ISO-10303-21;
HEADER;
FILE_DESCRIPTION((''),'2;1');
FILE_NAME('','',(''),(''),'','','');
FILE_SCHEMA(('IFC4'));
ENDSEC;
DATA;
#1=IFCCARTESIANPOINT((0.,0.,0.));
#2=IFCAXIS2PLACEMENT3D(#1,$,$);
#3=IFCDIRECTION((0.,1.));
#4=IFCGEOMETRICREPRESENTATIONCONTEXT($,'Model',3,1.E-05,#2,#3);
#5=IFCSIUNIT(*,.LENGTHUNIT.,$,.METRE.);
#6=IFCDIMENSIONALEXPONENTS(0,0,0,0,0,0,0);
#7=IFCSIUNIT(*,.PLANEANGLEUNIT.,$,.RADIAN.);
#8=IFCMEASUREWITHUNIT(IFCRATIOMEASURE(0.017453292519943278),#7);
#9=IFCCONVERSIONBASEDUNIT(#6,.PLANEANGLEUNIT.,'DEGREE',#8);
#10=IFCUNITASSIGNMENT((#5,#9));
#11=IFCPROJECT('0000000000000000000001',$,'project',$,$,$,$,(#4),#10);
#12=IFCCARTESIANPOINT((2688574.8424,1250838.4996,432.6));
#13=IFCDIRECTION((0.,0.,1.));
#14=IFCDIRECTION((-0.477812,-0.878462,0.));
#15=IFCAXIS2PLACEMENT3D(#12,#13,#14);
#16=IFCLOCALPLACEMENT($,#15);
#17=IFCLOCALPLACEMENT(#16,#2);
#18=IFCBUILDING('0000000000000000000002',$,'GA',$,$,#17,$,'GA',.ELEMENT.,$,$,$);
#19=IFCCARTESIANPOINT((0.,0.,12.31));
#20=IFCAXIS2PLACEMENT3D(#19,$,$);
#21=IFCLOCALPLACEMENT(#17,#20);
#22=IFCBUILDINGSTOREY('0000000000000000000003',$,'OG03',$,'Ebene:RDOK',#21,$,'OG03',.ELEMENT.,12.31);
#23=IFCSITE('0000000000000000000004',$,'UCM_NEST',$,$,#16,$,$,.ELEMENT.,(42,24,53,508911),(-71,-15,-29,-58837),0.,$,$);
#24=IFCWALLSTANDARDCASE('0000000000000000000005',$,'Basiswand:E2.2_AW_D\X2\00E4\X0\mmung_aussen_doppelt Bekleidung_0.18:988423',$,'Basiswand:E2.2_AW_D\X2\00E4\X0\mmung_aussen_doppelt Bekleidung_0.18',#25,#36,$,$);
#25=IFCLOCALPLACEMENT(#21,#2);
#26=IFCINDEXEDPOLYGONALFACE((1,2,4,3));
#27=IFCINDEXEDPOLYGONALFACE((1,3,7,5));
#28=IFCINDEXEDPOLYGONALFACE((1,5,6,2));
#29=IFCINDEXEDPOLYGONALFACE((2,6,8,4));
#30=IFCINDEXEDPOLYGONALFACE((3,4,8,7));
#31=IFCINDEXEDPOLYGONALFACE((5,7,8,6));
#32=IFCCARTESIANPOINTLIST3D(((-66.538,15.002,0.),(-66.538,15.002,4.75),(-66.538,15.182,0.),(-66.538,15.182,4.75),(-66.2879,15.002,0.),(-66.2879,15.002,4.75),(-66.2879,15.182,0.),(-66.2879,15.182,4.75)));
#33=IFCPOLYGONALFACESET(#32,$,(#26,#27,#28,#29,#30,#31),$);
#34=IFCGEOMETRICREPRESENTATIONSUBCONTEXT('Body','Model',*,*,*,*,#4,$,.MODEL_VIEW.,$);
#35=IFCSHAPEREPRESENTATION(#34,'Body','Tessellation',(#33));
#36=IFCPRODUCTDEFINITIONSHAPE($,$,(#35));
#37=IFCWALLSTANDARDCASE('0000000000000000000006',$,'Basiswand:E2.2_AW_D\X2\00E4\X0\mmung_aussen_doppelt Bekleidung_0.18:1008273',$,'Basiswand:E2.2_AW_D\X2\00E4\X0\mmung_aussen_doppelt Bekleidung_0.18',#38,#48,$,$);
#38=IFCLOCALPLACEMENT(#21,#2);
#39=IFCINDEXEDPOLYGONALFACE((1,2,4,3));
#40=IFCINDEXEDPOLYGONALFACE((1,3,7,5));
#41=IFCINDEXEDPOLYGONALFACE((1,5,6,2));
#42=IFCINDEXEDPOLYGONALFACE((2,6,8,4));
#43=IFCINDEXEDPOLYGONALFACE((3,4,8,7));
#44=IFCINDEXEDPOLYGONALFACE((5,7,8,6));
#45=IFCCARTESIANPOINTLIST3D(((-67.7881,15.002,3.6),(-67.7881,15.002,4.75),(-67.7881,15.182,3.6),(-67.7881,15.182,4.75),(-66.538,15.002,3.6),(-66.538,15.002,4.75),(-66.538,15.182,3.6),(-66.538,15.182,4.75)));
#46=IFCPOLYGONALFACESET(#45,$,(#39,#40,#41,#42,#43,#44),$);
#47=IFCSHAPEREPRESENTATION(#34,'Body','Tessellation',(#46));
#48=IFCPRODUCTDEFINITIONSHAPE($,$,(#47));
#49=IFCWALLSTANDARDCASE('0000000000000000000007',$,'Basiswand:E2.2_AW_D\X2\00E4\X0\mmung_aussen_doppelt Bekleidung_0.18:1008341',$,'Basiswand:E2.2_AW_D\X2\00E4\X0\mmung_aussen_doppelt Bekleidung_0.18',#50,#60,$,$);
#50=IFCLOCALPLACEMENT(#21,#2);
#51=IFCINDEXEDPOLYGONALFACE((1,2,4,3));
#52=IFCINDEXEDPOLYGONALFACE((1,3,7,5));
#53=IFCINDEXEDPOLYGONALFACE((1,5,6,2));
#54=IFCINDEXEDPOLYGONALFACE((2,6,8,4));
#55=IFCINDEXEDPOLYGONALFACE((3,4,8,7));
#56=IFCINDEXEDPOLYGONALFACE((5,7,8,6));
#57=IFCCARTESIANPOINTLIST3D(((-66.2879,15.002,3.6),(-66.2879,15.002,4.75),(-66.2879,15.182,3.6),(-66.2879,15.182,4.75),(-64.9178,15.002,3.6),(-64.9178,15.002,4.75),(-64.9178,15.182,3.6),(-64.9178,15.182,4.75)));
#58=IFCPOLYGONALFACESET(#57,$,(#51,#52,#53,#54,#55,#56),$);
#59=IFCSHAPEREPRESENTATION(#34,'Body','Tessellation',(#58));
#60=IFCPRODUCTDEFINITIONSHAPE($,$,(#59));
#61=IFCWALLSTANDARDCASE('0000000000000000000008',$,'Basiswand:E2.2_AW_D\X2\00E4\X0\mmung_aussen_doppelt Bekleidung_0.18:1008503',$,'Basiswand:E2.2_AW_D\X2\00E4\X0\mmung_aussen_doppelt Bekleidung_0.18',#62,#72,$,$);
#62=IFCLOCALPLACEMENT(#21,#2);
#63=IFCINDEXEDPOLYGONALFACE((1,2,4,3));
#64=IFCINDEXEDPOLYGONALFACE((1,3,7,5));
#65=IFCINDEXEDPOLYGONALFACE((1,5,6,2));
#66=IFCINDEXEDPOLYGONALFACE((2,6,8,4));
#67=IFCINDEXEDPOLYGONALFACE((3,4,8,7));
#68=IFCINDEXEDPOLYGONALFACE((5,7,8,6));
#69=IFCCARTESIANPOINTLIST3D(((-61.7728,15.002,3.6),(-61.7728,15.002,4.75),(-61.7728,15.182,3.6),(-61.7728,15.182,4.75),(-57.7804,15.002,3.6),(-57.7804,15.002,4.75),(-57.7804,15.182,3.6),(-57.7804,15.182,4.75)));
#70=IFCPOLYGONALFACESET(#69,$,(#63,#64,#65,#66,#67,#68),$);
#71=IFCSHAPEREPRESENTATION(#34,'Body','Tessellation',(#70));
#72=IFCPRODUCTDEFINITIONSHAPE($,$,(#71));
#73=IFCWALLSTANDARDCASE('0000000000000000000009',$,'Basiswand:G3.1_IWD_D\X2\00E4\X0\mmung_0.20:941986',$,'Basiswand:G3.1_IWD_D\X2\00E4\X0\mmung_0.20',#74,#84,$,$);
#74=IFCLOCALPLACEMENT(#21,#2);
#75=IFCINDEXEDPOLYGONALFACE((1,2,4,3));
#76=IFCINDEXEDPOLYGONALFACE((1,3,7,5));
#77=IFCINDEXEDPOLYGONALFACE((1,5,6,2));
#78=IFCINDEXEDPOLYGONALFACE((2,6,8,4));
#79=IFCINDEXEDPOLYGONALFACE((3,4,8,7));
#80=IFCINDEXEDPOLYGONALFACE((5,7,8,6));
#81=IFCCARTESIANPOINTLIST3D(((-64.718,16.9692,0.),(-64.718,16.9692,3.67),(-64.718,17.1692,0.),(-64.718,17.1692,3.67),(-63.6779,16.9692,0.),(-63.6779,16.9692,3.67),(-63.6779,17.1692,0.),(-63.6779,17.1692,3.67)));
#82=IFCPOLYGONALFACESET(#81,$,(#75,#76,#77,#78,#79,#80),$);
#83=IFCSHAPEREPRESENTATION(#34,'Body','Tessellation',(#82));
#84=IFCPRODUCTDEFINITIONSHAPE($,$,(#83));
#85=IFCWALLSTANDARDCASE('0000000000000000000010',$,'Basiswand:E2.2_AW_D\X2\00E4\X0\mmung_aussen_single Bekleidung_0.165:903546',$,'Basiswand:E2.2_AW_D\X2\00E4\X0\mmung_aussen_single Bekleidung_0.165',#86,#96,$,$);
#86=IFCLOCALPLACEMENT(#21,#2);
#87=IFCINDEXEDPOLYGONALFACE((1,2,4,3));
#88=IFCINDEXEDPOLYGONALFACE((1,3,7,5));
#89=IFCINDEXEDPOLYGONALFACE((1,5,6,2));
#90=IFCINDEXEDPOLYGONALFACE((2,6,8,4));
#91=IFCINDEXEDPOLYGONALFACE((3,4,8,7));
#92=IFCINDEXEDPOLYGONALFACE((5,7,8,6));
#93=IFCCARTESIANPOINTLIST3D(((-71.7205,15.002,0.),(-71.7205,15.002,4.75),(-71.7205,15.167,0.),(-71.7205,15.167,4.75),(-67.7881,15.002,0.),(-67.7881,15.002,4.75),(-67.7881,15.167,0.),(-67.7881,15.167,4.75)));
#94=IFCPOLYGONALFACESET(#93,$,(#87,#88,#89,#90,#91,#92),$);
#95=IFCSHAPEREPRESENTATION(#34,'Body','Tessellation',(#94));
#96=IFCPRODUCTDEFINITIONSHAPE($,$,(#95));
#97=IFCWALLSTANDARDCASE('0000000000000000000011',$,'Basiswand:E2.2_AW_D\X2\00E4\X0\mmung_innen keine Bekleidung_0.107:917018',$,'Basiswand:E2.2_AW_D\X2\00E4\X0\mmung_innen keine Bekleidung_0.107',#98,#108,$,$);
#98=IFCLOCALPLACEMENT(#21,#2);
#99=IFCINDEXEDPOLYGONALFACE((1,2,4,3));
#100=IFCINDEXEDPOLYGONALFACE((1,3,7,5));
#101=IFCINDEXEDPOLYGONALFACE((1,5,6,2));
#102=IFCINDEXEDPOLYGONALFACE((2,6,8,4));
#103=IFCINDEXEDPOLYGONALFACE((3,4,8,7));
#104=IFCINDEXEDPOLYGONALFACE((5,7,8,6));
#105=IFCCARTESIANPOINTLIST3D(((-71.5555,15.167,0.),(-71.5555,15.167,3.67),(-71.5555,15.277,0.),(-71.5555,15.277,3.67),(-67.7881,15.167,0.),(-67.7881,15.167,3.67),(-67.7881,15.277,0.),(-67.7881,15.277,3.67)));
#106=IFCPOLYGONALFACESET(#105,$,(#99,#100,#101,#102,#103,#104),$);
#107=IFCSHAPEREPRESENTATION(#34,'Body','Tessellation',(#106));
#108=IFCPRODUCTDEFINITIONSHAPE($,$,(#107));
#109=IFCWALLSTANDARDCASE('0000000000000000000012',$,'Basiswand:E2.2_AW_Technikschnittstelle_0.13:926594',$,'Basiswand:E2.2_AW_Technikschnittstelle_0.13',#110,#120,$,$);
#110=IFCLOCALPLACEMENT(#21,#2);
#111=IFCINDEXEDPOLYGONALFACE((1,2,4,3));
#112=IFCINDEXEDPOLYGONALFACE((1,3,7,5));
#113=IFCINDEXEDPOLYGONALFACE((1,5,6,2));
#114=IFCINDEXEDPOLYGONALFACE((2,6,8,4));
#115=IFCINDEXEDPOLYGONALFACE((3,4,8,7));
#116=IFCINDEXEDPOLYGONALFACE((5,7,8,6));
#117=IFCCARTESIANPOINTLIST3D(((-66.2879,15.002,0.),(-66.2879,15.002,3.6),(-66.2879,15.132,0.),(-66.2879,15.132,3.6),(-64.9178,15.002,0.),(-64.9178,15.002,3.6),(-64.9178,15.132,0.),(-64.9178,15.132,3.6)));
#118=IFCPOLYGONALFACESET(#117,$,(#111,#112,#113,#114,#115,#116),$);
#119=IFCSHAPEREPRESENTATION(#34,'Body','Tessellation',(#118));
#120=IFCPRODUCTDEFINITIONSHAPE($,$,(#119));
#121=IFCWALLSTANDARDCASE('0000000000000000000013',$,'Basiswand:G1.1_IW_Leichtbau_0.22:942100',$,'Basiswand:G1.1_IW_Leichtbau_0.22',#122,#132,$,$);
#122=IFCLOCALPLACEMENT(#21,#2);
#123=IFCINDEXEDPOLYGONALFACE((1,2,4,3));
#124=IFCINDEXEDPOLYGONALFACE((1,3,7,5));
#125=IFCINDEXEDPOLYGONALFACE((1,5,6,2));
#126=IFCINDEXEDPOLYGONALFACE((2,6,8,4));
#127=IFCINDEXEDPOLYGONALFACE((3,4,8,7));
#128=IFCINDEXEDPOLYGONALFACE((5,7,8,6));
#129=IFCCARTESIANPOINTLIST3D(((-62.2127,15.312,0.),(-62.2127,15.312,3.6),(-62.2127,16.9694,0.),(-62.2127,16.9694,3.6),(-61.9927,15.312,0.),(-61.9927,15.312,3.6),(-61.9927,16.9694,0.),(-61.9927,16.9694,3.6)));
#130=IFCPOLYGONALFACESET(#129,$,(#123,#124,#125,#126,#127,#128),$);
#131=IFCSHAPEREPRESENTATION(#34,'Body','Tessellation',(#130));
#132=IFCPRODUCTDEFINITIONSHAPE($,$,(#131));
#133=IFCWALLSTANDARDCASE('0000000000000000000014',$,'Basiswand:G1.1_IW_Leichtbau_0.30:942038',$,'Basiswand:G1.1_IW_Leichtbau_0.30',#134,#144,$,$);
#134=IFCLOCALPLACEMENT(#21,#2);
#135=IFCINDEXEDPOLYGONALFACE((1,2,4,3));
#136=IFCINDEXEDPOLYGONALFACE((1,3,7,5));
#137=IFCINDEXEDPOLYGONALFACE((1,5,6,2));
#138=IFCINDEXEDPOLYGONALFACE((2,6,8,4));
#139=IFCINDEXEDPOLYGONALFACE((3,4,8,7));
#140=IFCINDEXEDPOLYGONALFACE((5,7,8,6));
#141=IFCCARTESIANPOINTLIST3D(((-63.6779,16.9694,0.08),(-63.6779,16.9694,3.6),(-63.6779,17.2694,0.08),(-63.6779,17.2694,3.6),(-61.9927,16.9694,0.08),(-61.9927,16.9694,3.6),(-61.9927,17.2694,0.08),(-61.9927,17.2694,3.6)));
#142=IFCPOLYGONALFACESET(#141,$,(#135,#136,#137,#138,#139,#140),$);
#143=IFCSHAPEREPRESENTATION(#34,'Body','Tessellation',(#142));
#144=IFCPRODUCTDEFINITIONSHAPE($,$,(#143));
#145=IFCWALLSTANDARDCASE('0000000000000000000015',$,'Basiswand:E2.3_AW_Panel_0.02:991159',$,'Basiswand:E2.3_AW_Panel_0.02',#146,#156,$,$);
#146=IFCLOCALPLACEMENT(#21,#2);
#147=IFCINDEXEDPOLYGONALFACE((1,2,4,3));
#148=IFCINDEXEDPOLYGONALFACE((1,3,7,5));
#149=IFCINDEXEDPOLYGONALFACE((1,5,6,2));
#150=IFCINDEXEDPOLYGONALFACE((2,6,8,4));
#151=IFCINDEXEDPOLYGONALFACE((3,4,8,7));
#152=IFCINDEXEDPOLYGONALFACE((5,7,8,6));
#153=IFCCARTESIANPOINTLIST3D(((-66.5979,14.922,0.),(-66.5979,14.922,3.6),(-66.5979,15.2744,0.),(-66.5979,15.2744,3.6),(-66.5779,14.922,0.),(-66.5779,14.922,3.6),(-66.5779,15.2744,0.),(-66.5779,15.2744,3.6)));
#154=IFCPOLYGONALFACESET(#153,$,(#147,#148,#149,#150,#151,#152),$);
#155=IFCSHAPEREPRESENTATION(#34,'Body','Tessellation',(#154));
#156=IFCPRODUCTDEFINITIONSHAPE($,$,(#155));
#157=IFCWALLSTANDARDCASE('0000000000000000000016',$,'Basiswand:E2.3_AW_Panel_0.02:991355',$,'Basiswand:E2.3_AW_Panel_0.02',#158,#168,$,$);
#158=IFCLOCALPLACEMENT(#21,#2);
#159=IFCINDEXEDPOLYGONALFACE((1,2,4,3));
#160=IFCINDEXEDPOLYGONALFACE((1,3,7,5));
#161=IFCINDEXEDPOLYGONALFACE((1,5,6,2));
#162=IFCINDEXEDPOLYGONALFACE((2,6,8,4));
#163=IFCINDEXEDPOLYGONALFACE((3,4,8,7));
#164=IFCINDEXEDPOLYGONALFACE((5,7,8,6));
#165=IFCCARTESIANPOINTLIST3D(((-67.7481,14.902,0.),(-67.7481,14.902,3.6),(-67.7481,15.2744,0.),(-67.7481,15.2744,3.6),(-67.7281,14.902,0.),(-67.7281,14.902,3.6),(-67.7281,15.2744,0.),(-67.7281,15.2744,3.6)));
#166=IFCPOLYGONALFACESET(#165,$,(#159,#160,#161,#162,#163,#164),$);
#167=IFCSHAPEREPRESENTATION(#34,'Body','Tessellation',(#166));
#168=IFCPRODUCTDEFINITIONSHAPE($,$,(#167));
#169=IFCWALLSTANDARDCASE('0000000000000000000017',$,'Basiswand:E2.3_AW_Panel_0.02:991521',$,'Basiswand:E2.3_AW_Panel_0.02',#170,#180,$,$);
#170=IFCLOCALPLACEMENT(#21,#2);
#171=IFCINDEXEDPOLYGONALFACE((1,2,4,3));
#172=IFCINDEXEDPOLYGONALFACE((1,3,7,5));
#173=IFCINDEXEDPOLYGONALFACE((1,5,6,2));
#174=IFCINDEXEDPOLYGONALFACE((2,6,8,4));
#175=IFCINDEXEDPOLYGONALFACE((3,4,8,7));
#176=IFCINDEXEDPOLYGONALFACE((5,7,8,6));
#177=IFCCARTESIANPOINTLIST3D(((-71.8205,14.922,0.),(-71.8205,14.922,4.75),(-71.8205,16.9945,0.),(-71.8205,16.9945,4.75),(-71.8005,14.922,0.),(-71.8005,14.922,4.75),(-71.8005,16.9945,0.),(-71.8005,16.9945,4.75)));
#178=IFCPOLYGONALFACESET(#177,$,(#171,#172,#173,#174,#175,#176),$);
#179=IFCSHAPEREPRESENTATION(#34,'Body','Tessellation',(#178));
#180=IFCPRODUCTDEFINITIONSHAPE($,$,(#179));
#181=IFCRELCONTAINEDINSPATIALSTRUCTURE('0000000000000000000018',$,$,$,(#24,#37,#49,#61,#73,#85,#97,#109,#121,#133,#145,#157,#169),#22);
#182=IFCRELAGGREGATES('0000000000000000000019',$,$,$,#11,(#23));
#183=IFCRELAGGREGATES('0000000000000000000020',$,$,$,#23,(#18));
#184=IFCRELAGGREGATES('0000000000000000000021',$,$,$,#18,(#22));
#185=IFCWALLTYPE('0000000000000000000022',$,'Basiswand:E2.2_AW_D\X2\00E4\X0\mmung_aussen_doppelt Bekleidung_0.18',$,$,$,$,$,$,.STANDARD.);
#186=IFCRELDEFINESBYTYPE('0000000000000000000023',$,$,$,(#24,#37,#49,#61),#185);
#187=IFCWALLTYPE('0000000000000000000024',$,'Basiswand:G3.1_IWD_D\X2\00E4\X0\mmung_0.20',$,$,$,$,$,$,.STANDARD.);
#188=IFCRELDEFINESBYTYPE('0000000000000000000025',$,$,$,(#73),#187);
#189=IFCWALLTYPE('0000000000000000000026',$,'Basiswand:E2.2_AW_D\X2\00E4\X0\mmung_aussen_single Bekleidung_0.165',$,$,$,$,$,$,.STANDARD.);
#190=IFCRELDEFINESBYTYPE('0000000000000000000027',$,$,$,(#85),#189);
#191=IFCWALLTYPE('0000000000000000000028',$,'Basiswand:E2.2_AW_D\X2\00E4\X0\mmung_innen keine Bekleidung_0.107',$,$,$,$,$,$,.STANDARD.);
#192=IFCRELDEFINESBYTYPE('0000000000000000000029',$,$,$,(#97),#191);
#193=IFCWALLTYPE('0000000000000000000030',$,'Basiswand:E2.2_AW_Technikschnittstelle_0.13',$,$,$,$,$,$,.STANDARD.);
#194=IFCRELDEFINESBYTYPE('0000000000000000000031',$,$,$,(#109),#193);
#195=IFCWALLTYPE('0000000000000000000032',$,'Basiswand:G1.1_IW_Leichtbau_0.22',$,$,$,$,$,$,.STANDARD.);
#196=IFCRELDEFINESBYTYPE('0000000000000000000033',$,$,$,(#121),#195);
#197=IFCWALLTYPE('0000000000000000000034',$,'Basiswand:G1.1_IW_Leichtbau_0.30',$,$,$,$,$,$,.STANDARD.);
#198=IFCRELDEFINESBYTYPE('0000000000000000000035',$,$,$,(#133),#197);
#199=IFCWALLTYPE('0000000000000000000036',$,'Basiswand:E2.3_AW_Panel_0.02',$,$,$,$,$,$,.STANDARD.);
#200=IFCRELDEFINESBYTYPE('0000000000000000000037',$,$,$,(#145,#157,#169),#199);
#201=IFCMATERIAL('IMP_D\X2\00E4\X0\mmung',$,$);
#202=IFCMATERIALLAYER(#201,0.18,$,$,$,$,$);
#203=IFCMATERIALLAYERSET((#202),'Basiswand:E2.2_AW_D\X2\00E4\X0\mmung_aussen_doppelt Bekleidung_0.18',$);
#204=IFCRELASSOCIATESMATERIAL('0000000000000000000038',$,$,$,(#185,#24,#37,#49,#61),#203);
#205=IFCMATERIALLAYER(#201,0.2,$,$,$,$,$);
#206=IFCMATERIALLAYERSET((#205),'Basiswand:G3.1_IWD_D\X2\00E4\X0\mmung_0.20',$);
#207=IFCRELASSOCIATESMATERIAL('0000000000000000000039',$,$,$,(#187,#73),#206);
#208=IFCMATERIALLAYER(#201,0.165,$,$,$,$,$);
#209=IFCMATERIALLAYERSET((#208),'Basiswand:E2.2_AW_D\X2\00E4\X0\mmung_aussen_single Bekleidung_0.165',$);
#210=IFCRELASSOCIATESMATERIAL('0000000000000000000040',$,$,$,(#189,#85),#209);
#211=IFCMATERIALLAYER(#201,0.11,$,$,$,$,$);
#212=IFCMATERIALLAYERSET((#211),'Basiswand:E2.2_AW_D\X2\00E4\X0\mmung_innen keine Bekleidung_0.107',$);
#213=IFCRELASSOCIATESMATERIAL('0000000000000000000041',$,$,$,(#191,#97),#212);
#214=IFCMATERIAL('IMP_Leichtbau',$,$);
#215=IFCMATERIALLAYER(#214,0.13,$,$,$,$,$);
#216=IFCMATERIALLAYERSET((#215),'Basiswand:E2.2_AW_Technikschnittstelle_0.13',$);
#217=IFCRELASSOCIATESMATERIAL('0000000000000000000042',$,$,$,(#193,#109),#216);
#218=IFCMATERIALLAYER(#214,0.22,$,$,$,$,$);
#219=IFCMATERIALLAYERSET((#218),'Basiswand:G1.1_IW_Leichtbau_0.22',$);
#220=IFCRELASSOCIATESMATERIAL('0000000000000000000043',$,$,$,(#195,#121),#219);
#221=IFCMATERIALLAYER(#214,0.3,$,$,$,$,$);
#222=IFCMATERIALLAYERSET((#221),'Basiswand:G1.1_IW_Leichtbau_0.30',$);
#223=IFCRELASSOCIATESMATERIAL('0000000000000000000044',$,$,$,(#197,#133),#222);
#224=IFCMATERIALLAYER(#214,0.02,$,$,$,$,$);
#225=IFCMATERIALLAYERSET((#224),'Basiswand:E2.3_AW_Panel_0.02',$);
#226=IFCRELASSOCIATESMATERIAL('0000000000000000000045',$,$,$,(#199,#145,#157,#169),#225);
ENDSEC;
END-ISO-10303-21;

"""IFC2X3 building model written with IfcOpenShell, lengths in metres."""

from ifc_helpers import new_model, entity, si_unit, converted_unit, direction, frame, frame_2d, origin, place, context, subcontext, project, spatial, polyline, rectangle, extrude, clip, bounded_halfspace, material, layer, layer_set, layer_usage, type_object, element, save


model = new_model("IFC2X3")

# Units and contexts
model_context = context("Model", 3, precision=1e-05, world=origin(), true_north=direction((0.0, 1.0)))
body_context = subcontext(model_context, "Body", "Model", "MODEL_VIEW")
ifc_project = project(units=[si_unit("LENGTHUNIT", "METRE"), converted_unit("PLANEANGLEUNIT", "DEGREE", entity("IfcRatioMeasure", 0.017453292519943278), si_unit("PLANEANGLEUNIT", "RADIAN"), dimensions=[0, 0, 0, 0, 0, 0, 0])], contexts=[model_context])

# Site, building, storey
site_placement = place(None, frame((2688574.8424, 1250838.4996, 432.6), z_axis=(0.0, 0.0, 1.0), x_axis=(-0.477812, -0.878462, 0.0)))
site = spatial("IfcSite", under=ifc_project, at=site_placement, Name="UCM_NEST", CompositionType="ELEMENT", RefLatitude=(42, 24, 53, 508911), RefLongitude=(-71, -15, -29, -58837), RefElevation=0.0)
building_placement = place(site_placement, origin())
building = spatial("IfcBuilding", under=site, at=building_placement, Name="GA", LongName="GA", CompositionType="ELEMENT")
storey_placement = place(building_placement, frame((0.0, 0.0, 12.31)))
storey = spatial("IfcBuildingStorey", under=building, at=storey_placement, Name="OG03", ObjectType="Ebene:RDOK", LongName="OG03", CompositionType="ELEMENT", Elevation=12.31)

# Walls
ifc_material_1 = material(Name="IMP_Dämmung")
ifc_layer_1 = layer(ifc_material_1, 0.18)
ifc_layer_set_1 = layer_set([ifc_layer_1], Name="Basiswand:E2.2_AW_Dämmung_aussen_doppelt Bekleidung_0.18")
ifc_layer_usage_1 = layer_usage(ifc_layer_set_1, "AXIS2", "NEGATIVE", 0.09)
wall_type_1 = type_object("IfcWallType", Name="Basiswand:E2.2_AW_Dämmung_aussen_doppelt Bekleidung_0.18", PredefinedType="STANDARD", material=ifc_layer_set_1)
wall_1_placement = place(storey_placement, frame((-66.2879, 15.092, 0.0), z_axis=(0.0, 0.0, 1.0), x_axis=(-1.0, 0.0, 0.0)))
element("IfcWallStandardCase", 1, at=wall_1_placement, inside=storey, type_object=wall_type_1, material=ifc_layer_usage_1, Name="Basiswand:E2.2_AW_Dämmung_aussen_doppelt Bekleidung_0.18:988423", ObjectType="Basiswand:E2.2_AW_Dämmung_aussen_doppelt Bekleidung_0.18", context=body_context, shape_type="SweptSolid", body=[
    extrude(rectangle(XDim=0.2502, YDim=0.18, at=frame_2d((0.1251, 0.0), x_axis=(-1.0, 0.0))), origin(), (0.0, 0.0, 1.0), 4.75),
])
wall_2_placement = place(storey_placement, frame((-67.7881, 15.092, 3.6)))
element("IfcWallStandardCase", 2, at=wall_2_placement, inside=storey, type_object=wall_type_1, material=ifc_layer_usage_1, Name="Basiswand:E2.2_AW_Dämmung_aussen_doppelt Bekleidung_0.18:1008273", ObjectType="Basiswand:E2.2_AW_Dämmung_aussen_doppelt Bekleidung_0.18", context=body_context, shape_type="SweptSolid", body=[
    extrude(rectangle(XDim=1.2501, YDim=0.18, at=frame_2d((0.625, 0.0), x_axis=(-1.0, 0.0))), origin(), (0.0, 0.0, 1.0), 1.15),
])
wall_3_placement = place(storey_placement, frame((-66.2879, 15.092, 3.6)))
element("IfcWallStandardCase", 3, at=wall_3_placement, inside=storey, type_object=wall_type_1, material=ifc_layer_usage_1, Name="Basiswand:E2.2_AW_Dämmung_aussen_doppelt Bekleidung_0.18:1008341", ObjectType="Basiswand:E2.2_AW_Dämmung_aussen_doppelt Bekleidung_0.18", context=body_context, shape_type="SweptSolid", body=[
    extrude(rectangle(XDim=1.3701, YDim=0.18, at=frame_2d((0.685, 0.0), x_axis=(-1.0, 0.0))), origin(), (0.0, 0.0, 1.0), 1.15),
])
wall_4_placement = place(storey_placement, frame((-61.7728, 15.092, 3.6)))
element("IfcWallStandardCase", 4, at=wall_4_placement, inside=storey, type_object=wall_type_1, material=ifc_layer_usage_1, Name="Basiswand:E2.2_AW_Dämmung_aussen_doppelt Bekleidung_0.18:1008503", ObjectType="Basiswand:E2.2_AW_Dämmung_aussen_doppelt Bekleidung_0.18", context=body_context, shape_type="SweptSolid", body=[
    extrude(rectangle(XDim=3.9923, YDim=0.18, at=frame_2d((1.9962, 0.0), x_axis=(-1.0, 0.0))), origin(), (0.0, 0.0, 1.0), 1.15),
])
ifc_layer_2 = layer(ifc_material_1, 0.2)
ifc_layer_set_2 = layer_set([ifc_layer_2], Name="Basiswand:G3.1_IWD_Dämmung_0.20")
ifc_layer_usage_2 = layer_usage(ifc_layer_set_2, "AXIS2", "NEGATIVE", 0.1)
wall_type_2 = type_object("IfcWallType", Name="Basiswand:G3.1_IWD_Dämmung_0.20", PredefinedType="STANDARD", material=ifc_layer_set_2)
wall_5_placement = place(storey_placement, frame((-64.718, 17.0692, 0.0)))
element("IfcWallStandardCase", 5, at=wall_5_placement, inside=storey, type_object=wall_type_2, material=ifc_layer_usage_2, Name="Basiswand:G3.1_IWD_Dämmung_0.20:941986", ObjectType="Basiswand:G3.1_IWD_Dämmung_0.20", context=body_context, shape_type="SweptSolid", body=[
    extrude(rectangle(XDim=1.0401, YDim=0.2, at=frame_2d((0.52, 0.0), x_axis=(-1.0, 0.0))), origin(), (0.0, 0.0, 1.0), 3.67),
])
ifc_layer_3 = layer(ifc_material_1, 0.165)
ifc_layer_set_3 = layer_set([ifc_layer_3], Name="Basiswand:E2.2_AW_Dämmung_aussen_single Bekleidung_0.165")
ifc_layer_usage_3 = layer_usage(ifc_layer_set_3, "AXIS2", "NEGATIVE", 0.0825)
wall_type_3 = type_object("IfcWallType", Name="Basiswand:E2.2_AW_Dämmung_aussen_single Bekleidung_0.165", PredefinedType="STANDARD", material=ifc_layer_set_3)
wall_6_placement = place(storey_placement, frame((-67.7881, 15.0845, 0.0), z_axis=(0.0, 0.0, 1.0), x_axis=(-1.0, 0.0, 0.0)))
element("IfcWallStandardCase", 6, at=wall_6_placement, inside=storey, type_object=wall_type_3, material=ifc_layer_usage_3, Name="Basiswand:E2.2_AW_Dämmung_aussen_single Bekleidung_0.165:903546", ObjectType="Basiswand:E2.2_AW_Dämmung_aussen_single Bekleidung_0.165", context=body_context, shape_type="SweptSolid", body=[
    extrude(rectangle(XDim=3.9324, YDim=0.165, at=frame_2d((1.9662, 0.0), x_axis=(-1.0, 0.0))), origin(), (0.0, 0.0, 1.0), 4.75),
])

# Wall
ifc_layer_4 = layer(ifc_material_1, 0.11)
ifc_layer_set_4 = layer_set([ifc_layer_4], Name="Basiswand:E2.2_AW_Dämmung_innen keine Bekleidung_0.107")
ifc_layer_usage_4 = layer_usage(ifc_layer_set_4, "AXIS2", "NEGATIVE", 0.055)
wall_type_4 = type_object("IfcWallType", Name="Basiswand:E2.2_AW_Dämmung_innen keine Bekleidung_0.107", PredefinedType="STANDARD", material=ifc_layer_set_4)
wall_7_placement = place(storey_placement, frame((-67.7881, 15.222, 0.0), z_axis=(0.0, 0.0, 1.0), x_axis=(-1.0, 0.0, 0.0)))
element("IfcWallStandardCase", 7, at=wall_7_placement, inside=storey, type_object=wall_type_4, material=ifc_layer_usage_4, Name="Basiswand:E2.2_AW_Dämmung_innen keine Bekleidung_0.107:917018", ObjectType="Basiswand:E2.2_AW_Dämmung_innen keine Bekleidung_0.107", context=body_context, shape_type="SweptSolid", body=[
    extrude(rectangle(XDim=3.7674, YDim=0.11, at=frame_2d((1.8837, 0.0), x_axis=(-1.0, 0.0))), origin(), (0.0, 0.0, 1.0), 3.67),
])

# Walls
ifc_material_2 = material(Name="IMP_Leichtbau")
ifc_layer_5 = layer(ifc_material_2, 0.13)
ifc_layer_set_5 = layer_set([ifc_layer_5], Name="Basiswand:E2.2_AW_Technikschnittstelle_0.13")
ifc_layer_usage_5 = layer_usage(ifc_layer_set_5, "AXIS2", "NEGATIVE", 0.065)
wall_type_5 = type_object("IfcWallType", Name="Basiswand:E2.2_AW_Technikschnittstelle_0.13", PredefinedType="STANDARD", material=ifc_layer_set_5)
wall_8_placement = place(storey_placement, frame((-64.9178, 15.067, 0.0), z_axis=(0.0, 0.0, 1.0), x_axis=(-1.0, 0.0, 0.0)))
element("IfcWallStandardCase", 8, at=wall_8_placement, inside=storey, type_object=wall_type_5, material=ifc_layer_usage_5, Name="Basiswand:E2.2_AW_Technikschnittstelle_0.13:926594", ObjectType="Basiswand:E2.2_AW_Technikschnittstelle_0.13", context=body_context, shape_type="SweptSolid", body=[
    extrude(rectangle(XDim=1.3701, YDim=0.13, at=frame_2d((0.685, 0.0), x_axis=(-1.0, 0.0))), origin(), (0.0, 0.0, 1.0), 3.6),
])
ifc_layer_6 = layer(ifc_material_2, 0.22)
ifc_layer_set_6 = layer_set([ifc_layer_6], Name="Basiswand:G1.1_IW_Leichtbau_0.22")
ifc_layer_usage_6 = layer_usage(ifc_layer_set_6, "AXIS2", "NEGATIVE", 0.11)
wall_type_6 = type_object("IfcWallType", Name="Basiswand:G1.1_IW_Leichtbau_0.22", PredefinedType="STANDARD", material=ifc_layer_set_6)
wall_9_placement = place(storey_placement, frame((-62.1027, 15.312, 0.0), z_axis=(0.0, 0.0, 1.0), x_axis=(0.0, 1.0, 0.0)))
element("IfcWallStandardCase", 9, at=wall_9_placement, inside=storey, type_object=wall_type_6, material=ifc_layer_usage_6, Name="Basiswand:G1.1_IW_Leichtbau_0.22:942100", ObjectType="Basiswand:G1.1_IW_Leichtbau_0.22", context=body_context, shape_type="SweptSolid", body=[
    extrude(rectangle(XDim=1.6575, YDim=0.22, at=frame_2d((0.8287, 0.0), x_axis=(-1.0, 0.0))), origin(), (0.0, 0.0, 1.0), 3.6),
])
ifc_layer_7 = layer(ifc_material_2, 0.3)
ifc_layer_set_7 = layer_set([ifc_layer_7], Name="Basiswand:G1.1_IW_Leichtbau_0.30")
ifc_layer_usage_7 = layer_usage(ifc_layer_set_7, "AXIS2", "NEGATIVE", 0.15)
wall_type_7 = type_object("IfcWallType", Name="Basiswand:G1.1_IW_Leichtbau_0.30", PredefinedType="STANDARD", material=ifc_layer_set_7)
wall_10_placement = place(storey_placement, frame((-61.9927, 17.1194, 0.08), z_axis=(0.0, 0.0, 1.0), x_axis=(-1.0, 0.0, 0.0)))
element("IfcWallStandardCase", 10, at=wall_10_placement, inside=storey, type_object=wall_type_7, material=ifc_layer_usage_7, Name="Basiswand:G1.1_IW_Leichtbau_0.30:942038", ObjectType="Basiswand:G1.1_IW_Leichtbau_0.30", context=body_context, shape_type="Clipping", body=[
    clip(extrude(rectangle(XDim=1.6852, YDim=0.3, at=frame_2d((0.8426, 0.0), x_axis=(-1.0, 0.0))), origin(), (0.0, 0.0, 1.0), 3.52), bounded_halfspace(frame((1.6852, -0.15, 0.0)), True, frame((1.6852, -0.15, 0.0)), polyline([(0.0, 0.0), (0.0, 0.3), (-1.6852, 0.3), (-1.6852, 0.0), (0.0, 0.0)]))),
])
ifc_layer_8 = layer(ifc_material_2, 0.02)
ifc_layer_set_8 = layer_set([ifc_layer_8], Name="Basiswand:E2.3_AW_Panel_0.02")
ifc_layer_usage_8 = layer_usage(ifc_layer_set_8, "AXIS2", "NEGATIVE", 0.01)
wall_type_8 = type_object("IfcWallType", Name="Basiswand:E2.3_AW_Panel_0.02", PredefinedType="STANDARD", material=ifc_layer_set_8)
wall_11_placement = place(storey_placement, frame((-66.5879, 14.922, 0.0), z_axis=(0.0, 0.0, 1.0), x_axis=(0.0, 1.0, 0.0)))
element("IfcWallStandardCase", 11, at=wall_11_placement, inside=storey, type_object=wall_type_8, material=ifc_layer_usage_8, Name="Basiswand:E2.3_AW_Panel_0.02:991159", ObjectType="Basiswand:E2.3_AW_Panel_0.02", context=body_context, shape_type="SweptSolid", body=[
    extrude(rectangle(XDim=0.3525, YDim=0.02, at=frame_2d((0.1762, 0.0), x_axis=(-1.0, 0.0))), origin(), (0.0, 0.0, 1.0), 3.6),
])
wall_12_placement = place(storey_placement, frame((-67.7381, 15.2744, 0.0), z_axis=(0.0, 0.0, 1.0), x_axis=(0.0, -1.0, 0.0)))
element("IfcWallStandardCase", 12, at=wall_12_placement, inside=storey, type_object=wall_type_8, material=ifc_layer_usage_8, Name="Basiswand:E2.3_AW_Panel_0.02:991355", ObjectType="Basiswand:E2.3_AW_Panel_0.02", context=body_context, shape_type="SweptSolid", body=[
    extrude(rectangle(XDim=0.3724, YDim=0.02, at=frame_2d((0.1862, 0.0), x_axis=(-1.0, 0.0))), origin(), (0.0, 0.0, 1.0), 3.6),
])
wall_13_placement = place(storey_placement, frame((-71.8105, 14.922, 0.0), z_axis=(0.0, 0.0, 1.0), x_axis=(0.0, 1.0, 0.0)))
element("IfcWallStandardCase", 13, at=wall_13_placement, inside=storey, type_object=wall_type_8, material=ifc_layer_usage_8, Name="Basiswand:E2.3_AW_Panel_0.02:991521", ObjectType="Basiswand:E2.3_AW_Panel_0.02", context=body_context, shape_type="SweptSolid", body=[
    extrude(rectangle(XDim=2.0725, YDim=0.02, at=frame_2d((1.0362, 0.0), x_axis=(-1.0, 0.0))), origin(), (0.0, 0.0, 1.0), 4.75),
])

save(model, "model.ifc")
